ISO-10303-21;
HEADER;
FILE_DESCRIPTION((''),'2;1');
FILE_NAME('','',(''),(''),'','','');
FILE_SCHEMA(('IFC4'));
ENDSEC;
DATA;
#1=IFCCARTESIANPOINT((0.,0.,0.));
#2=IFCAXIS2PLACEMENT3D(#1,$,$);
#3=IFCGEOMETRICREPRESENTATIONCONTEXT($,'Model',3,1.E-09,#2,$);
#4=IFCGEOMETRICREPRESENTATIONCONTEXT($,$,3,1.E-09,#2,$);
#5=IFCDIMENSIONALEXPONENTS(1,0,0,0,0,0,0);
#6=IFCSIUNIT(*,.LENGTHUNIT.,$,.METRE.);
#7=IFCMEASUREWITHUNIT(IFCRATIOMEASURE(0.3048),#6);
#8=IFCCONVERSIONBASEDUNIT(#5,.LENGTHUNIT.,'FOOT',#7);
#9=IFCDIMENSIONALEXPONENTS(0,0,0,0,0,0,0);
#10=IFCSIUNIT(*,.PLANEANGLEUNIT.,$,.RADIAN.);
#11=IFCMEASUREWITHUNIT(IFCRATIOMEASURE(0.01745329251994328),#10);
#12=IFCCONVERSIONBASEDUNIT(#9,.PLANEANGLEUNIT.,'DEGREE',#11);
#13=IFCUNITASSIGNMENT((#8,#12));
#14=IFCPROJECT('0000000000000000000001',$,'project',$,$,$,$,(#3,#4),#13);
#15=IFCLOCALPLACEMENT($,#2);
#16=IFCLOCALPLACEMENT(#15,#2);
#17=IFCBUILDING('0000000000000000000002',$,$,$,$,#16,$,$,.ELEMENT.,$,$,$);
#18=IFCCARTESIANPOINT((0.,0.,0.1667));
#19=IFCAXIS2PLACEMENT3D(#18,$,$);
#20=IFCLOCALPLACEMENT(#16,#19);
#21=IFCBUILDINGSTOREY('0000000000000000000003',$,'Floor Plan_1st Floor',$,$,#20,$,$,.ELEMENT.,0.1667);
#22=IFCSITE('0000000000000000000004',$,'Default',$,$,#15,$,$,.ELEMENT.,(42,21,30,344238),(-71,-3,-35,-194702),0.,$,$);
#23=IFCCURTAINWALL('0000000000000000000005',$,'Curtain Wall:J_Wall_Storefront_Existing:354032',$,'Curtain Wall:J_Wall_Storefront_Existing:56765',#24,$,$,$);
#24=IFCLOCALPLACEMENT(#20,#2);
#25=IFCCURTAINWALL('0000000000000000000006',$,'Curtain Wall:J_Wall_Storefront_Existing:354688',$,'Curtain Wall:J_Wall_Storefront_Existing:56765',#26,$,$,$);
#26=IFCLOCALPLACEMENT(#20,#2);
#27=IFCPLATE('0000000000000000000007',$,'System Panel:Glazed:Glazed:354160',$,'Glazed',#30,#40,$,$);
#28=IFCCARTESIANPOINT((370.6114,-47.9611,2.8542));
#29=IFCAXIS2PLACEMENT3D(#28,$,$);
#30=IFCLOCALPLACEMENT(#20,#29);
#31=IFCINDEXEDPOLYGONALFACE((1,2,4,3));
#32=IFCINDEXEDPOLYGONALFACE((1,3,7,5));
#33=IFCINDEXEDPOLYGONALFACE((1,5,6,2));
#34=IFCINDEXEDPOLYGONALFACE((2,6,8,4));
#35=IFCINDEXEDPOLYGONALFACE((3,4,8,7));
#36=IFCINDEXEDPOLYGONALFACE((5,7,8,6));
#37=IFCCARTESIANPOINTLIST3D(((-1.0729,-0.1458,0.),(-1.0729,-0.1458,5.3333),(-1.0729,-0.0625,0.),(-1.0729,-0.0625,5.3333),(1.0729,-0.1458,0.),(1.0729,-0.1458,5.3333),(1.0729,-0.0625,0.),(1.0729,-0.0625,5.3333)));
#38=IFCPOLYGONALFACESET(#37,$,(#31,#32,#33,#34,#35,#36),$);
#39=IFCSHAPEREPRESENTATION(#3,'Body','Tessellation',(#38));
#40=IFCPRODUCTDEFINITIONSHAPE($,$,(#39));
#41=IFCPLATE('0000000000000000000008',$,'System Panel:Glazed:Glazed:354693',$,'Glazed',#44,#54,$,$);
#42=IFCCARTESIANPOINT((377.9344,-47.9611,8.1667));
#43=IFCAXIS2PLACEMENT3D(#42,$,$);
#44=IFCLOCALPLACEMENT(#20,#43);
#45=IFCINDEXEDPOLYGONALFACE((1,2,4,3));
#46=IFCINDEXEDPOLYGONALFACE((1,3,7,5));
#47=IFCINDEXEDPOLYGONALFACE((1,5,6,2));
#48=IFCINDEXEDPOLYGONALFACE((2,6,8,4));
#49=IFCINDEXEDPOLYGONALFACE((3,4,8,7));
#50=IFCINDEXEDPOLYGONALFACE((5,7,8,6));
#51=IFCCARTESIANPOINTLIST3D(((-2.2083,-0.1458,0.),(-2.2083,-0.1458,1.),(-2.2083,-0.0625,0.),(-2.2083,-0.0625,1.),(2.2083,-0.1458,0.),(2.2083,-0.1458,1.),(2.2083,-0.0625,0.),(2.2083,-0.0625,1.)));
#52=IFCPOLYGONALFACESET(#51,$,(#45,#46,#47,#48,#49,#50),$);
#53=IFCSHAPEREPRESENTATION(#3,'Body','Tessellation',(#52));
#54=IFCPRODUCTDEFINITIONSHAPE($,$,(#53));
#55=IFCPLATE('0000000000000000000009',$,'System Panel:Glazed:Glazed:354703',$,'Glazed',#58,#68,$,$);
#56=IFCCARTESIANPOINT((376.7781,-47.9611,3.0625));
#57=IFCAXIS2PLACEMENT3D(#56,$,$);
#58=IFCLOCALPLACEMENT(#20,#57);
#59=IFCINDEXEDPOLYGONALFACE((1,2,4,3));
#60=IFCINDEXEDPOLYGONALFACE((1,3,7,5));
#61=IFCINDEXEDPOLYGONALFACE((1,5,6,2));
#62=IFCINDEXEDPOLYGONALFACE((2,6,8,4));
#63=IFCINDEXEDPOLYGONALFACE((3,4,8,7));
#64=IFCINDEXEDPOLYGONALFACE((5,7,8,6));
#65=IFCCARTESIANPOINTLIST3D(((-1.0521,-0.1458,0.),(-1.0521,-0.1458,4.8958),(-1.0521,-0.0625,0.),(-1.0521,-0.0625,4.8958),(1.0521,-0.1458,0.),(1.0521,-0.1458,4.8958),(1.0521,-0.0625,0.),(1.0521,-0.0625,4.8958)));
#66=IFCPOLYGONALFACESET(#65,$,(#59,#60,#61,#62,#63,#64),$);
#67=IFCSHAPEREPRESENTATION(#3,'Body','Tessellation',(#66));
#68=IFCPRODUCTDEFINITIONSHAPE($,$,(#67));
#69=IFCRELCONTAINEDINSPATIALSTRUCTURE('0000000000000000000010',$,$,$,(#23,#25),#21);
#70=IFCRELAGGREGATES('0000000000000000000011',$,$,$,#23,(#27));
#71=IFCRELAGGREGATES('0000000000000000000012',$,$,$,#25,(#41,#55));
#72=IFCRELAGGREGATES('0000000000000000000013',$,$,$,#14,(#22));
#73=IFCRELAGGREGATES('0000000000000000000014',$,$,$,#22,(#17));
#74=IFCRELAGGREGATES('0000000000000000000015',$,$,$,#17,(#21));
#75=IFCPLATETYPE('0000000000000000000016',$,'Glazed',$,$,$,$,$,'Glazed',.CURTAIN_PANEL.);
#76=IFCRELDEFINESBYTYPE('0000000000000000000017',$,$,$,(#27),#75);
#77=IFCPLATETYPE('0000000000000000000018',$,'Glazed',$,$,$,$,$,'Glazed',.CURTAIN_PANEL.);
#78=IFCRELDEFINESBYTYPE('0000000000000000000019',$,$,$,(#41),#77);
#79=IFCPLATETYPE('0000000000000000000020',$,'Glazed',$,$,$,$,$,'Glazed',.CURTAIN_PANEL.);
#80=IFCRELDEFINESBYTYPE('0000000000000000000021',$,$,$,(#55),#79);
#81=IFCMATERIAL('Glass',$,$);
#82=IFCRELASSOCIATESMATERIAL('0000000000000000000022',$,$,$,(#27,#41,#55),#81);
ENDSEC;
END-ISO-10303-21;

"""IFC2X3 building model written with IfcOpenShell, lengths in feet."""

from ifc_helpers import new_model, entity, si_unit, converted_unit, frame, origin, origin_2d_with_axis, place, context, project, spatial, rectangle, extrude, source, transform, mapped, material, type_object, type_shapes, element, aggregate, save


model = new_model("IFC2X3")

# Units and contexts
model_context = context("Model", 3, precision=1e-09, world=origin())
context_of_model = context(None, 3, precision=1e-09, world=origin())
ifc_project = project(units=[converted_unit("LENGTHUNIT", "FOOT", entity("IfcRatioMeasure", 0.3048), si_unit("LENGTHUNIT", "METRE"), dimensions=[1, 0, 0, 0, 0, 0, 0]), converted_unit("PLANEANGLEUNIT", "DEGREE", entity("IfcRatioMeasure", 0.01745329251994328), si_unit("PLANEANGLEUNIT", "RADIAN"), dimensions=[0, 0, 0, 0, 0, 0, 0])], contexts=[model_context, context_of_model])

# Site, building, storey
site_placement = place(None, origin())
site = spatial("IfcSite", under=ifc_project, at=site_placement, Name="Default", CompositionType="ELEMENT", RefLatitude=(42, 21, 30, 344238), RefLongitude=(-71, -3, -35, -194702), RefElevation=0.0)
building_placement = place(site_placement, origin())
building = spatial("IfcBuilding", under=site, at=building_placement, CompositionType="ELEMENT")
storey_placement = place(building_placement, frame((0.0, 0.0, 0.1667)))
storey = spatial("IfcBuildingStorey", under=building, at=storey_placement, Name="Floor Plan_1st Floor", CompositionType="ELEMENT", Elevation=0.1667)

# Curtain walls
curtain_wall_1_placement = place(storey_placement, origin())
curtain_wall_1 = element("IfcCurtainWall", 1, at=curtain_wall_1_placement, inside=storey, Name="Curtain Wall:J_Wall_Storefront_Existing:354032", ObjectType="Curtain Wall:J_Wall_Storefront_Existing:56765")
curtain_wall_2_placement = place(storey_placement, origin())
curtain_wall_2 = element("IfcCurtainWall", 2, at=curtain_wall_2_placement, inside=storey, Name="Curtain Wall:J_Wall_Storefront_Existing:354688", ObjectType="Curtain Wall:J_Wall_Storefront_Existing:56765")

# Plates
ifc_material_1 = material(Name="Glass")
plate_type_1 = type_object("IfcPlateType", Name="Glazed", ElementType="Glazed", PredefinedType="CURTAIN_PANEL")
shared_shape_1 = source(origin(), model_context, "Body", "SweptSolid", [
    extrude(rectangle(XDim=0.0833, YDim=2.1458, at=origin_2d_with_axis()), frame((0.0, -0.1042, 0.0), z_axis=(0.0, 0.0, 1.0), x_axis=(0.0, 1.0, 0.0)), (0.0, 0.0, 1.0), 5.3333),
])
type_shapes(plate_type_1, [shared_shape_1])
plate_1_placement = place(storey_placement, frame((370.6114, -47.9611, 2.8542)))
plate_1 = element("IfcPlate", 3, at=plate_1_placement, type_object=plate_type_1, material=ifc_material_1, Name="System Panel:Glazed:Glazed:354160", ObjectType="Glazed", context=model_context, shape_type="MappedRepresentation", body=[
    mapped(shared_shape_1, transform((0.0, 0.0, 0.0), scale=1.0)),
])
aggregate(curtain_wall_1, [plate_1])
plate_type_2 = type_object("IfcPlateType", Name="Glazed", ElementType="Glazed", PredefinedType="CURTAIN_PANEL")
shared_shape_2 = source(origin(), model_context, "Body", "SweptSolid", [
    extrude(rectangle(XDim=1.0, YDim=4.4167, at=origin_2d_with_axis()), frame((0.0, -0.1458, 0.5), z_axis=(0.0, 1.0, 0.0), x_axis=(0.0, 0.0, 1.0)), (0.0, 0.0, 1.0), 0.0833),
])
type_shapes(plate_type_2, [shared_shape_2])
plate_2_placement = place(storey_placement, frame((377.9344, -47.9611, 8.1667)))
plate_2 = element("IfcPlate", 4, at=plate_2_placement, type_object=plate_type_2, material=ifc_material_1, Name="System Panel:Glazed:Glazed:354693", ObjectType="Glazed", context=model_context, shape_type="MappedRepresentation", body=[
    mapped(shared_shape_2, transform((0.0, 0.0, 0.0), scale=1.0)),
])
plate_type_3 = type_object("IfcPlateType", Name="Glazed", ElementType="Glazed", PredefinedType="CURTAIN_PANEL")
shared_shape_3 = source(origin(), model_context, "Body", "SweptSolid", [
    extrude(rectangle(XDim=0.0833, YDim=2.1042, at=origin_2d_with_axis()), frame((0.0, -0.1042, 0.0), z_axis=(0.0, 0.0, 1.0), x_axis=(0.0, 1.0, 0.0)), (0.0, 0.0, 1.0), 4.8958),
])
type_shapes(plate_type_3, [shared_shape_3])
plate_3_placement = place(storey_placement, frame((376.7781, -47.9611, 3.0625)))
plate_3 = element("IfcPlate", 5, at=plate_3_placement, type_object=plate_type_3, material=ifc_material_1, Name="System Panel:Glazed:Glazed:354703", ObjectType="Glazed", context=model_context, shape_type="MappedRepresentation", body=[
    mapped(shared_shape_3, transform((0.0, 0.0, 0.0), scale=1.0)),
])
aggregate(curtain_wall_2, [plate_2, plate_3])

save(model, "model.ifc")
